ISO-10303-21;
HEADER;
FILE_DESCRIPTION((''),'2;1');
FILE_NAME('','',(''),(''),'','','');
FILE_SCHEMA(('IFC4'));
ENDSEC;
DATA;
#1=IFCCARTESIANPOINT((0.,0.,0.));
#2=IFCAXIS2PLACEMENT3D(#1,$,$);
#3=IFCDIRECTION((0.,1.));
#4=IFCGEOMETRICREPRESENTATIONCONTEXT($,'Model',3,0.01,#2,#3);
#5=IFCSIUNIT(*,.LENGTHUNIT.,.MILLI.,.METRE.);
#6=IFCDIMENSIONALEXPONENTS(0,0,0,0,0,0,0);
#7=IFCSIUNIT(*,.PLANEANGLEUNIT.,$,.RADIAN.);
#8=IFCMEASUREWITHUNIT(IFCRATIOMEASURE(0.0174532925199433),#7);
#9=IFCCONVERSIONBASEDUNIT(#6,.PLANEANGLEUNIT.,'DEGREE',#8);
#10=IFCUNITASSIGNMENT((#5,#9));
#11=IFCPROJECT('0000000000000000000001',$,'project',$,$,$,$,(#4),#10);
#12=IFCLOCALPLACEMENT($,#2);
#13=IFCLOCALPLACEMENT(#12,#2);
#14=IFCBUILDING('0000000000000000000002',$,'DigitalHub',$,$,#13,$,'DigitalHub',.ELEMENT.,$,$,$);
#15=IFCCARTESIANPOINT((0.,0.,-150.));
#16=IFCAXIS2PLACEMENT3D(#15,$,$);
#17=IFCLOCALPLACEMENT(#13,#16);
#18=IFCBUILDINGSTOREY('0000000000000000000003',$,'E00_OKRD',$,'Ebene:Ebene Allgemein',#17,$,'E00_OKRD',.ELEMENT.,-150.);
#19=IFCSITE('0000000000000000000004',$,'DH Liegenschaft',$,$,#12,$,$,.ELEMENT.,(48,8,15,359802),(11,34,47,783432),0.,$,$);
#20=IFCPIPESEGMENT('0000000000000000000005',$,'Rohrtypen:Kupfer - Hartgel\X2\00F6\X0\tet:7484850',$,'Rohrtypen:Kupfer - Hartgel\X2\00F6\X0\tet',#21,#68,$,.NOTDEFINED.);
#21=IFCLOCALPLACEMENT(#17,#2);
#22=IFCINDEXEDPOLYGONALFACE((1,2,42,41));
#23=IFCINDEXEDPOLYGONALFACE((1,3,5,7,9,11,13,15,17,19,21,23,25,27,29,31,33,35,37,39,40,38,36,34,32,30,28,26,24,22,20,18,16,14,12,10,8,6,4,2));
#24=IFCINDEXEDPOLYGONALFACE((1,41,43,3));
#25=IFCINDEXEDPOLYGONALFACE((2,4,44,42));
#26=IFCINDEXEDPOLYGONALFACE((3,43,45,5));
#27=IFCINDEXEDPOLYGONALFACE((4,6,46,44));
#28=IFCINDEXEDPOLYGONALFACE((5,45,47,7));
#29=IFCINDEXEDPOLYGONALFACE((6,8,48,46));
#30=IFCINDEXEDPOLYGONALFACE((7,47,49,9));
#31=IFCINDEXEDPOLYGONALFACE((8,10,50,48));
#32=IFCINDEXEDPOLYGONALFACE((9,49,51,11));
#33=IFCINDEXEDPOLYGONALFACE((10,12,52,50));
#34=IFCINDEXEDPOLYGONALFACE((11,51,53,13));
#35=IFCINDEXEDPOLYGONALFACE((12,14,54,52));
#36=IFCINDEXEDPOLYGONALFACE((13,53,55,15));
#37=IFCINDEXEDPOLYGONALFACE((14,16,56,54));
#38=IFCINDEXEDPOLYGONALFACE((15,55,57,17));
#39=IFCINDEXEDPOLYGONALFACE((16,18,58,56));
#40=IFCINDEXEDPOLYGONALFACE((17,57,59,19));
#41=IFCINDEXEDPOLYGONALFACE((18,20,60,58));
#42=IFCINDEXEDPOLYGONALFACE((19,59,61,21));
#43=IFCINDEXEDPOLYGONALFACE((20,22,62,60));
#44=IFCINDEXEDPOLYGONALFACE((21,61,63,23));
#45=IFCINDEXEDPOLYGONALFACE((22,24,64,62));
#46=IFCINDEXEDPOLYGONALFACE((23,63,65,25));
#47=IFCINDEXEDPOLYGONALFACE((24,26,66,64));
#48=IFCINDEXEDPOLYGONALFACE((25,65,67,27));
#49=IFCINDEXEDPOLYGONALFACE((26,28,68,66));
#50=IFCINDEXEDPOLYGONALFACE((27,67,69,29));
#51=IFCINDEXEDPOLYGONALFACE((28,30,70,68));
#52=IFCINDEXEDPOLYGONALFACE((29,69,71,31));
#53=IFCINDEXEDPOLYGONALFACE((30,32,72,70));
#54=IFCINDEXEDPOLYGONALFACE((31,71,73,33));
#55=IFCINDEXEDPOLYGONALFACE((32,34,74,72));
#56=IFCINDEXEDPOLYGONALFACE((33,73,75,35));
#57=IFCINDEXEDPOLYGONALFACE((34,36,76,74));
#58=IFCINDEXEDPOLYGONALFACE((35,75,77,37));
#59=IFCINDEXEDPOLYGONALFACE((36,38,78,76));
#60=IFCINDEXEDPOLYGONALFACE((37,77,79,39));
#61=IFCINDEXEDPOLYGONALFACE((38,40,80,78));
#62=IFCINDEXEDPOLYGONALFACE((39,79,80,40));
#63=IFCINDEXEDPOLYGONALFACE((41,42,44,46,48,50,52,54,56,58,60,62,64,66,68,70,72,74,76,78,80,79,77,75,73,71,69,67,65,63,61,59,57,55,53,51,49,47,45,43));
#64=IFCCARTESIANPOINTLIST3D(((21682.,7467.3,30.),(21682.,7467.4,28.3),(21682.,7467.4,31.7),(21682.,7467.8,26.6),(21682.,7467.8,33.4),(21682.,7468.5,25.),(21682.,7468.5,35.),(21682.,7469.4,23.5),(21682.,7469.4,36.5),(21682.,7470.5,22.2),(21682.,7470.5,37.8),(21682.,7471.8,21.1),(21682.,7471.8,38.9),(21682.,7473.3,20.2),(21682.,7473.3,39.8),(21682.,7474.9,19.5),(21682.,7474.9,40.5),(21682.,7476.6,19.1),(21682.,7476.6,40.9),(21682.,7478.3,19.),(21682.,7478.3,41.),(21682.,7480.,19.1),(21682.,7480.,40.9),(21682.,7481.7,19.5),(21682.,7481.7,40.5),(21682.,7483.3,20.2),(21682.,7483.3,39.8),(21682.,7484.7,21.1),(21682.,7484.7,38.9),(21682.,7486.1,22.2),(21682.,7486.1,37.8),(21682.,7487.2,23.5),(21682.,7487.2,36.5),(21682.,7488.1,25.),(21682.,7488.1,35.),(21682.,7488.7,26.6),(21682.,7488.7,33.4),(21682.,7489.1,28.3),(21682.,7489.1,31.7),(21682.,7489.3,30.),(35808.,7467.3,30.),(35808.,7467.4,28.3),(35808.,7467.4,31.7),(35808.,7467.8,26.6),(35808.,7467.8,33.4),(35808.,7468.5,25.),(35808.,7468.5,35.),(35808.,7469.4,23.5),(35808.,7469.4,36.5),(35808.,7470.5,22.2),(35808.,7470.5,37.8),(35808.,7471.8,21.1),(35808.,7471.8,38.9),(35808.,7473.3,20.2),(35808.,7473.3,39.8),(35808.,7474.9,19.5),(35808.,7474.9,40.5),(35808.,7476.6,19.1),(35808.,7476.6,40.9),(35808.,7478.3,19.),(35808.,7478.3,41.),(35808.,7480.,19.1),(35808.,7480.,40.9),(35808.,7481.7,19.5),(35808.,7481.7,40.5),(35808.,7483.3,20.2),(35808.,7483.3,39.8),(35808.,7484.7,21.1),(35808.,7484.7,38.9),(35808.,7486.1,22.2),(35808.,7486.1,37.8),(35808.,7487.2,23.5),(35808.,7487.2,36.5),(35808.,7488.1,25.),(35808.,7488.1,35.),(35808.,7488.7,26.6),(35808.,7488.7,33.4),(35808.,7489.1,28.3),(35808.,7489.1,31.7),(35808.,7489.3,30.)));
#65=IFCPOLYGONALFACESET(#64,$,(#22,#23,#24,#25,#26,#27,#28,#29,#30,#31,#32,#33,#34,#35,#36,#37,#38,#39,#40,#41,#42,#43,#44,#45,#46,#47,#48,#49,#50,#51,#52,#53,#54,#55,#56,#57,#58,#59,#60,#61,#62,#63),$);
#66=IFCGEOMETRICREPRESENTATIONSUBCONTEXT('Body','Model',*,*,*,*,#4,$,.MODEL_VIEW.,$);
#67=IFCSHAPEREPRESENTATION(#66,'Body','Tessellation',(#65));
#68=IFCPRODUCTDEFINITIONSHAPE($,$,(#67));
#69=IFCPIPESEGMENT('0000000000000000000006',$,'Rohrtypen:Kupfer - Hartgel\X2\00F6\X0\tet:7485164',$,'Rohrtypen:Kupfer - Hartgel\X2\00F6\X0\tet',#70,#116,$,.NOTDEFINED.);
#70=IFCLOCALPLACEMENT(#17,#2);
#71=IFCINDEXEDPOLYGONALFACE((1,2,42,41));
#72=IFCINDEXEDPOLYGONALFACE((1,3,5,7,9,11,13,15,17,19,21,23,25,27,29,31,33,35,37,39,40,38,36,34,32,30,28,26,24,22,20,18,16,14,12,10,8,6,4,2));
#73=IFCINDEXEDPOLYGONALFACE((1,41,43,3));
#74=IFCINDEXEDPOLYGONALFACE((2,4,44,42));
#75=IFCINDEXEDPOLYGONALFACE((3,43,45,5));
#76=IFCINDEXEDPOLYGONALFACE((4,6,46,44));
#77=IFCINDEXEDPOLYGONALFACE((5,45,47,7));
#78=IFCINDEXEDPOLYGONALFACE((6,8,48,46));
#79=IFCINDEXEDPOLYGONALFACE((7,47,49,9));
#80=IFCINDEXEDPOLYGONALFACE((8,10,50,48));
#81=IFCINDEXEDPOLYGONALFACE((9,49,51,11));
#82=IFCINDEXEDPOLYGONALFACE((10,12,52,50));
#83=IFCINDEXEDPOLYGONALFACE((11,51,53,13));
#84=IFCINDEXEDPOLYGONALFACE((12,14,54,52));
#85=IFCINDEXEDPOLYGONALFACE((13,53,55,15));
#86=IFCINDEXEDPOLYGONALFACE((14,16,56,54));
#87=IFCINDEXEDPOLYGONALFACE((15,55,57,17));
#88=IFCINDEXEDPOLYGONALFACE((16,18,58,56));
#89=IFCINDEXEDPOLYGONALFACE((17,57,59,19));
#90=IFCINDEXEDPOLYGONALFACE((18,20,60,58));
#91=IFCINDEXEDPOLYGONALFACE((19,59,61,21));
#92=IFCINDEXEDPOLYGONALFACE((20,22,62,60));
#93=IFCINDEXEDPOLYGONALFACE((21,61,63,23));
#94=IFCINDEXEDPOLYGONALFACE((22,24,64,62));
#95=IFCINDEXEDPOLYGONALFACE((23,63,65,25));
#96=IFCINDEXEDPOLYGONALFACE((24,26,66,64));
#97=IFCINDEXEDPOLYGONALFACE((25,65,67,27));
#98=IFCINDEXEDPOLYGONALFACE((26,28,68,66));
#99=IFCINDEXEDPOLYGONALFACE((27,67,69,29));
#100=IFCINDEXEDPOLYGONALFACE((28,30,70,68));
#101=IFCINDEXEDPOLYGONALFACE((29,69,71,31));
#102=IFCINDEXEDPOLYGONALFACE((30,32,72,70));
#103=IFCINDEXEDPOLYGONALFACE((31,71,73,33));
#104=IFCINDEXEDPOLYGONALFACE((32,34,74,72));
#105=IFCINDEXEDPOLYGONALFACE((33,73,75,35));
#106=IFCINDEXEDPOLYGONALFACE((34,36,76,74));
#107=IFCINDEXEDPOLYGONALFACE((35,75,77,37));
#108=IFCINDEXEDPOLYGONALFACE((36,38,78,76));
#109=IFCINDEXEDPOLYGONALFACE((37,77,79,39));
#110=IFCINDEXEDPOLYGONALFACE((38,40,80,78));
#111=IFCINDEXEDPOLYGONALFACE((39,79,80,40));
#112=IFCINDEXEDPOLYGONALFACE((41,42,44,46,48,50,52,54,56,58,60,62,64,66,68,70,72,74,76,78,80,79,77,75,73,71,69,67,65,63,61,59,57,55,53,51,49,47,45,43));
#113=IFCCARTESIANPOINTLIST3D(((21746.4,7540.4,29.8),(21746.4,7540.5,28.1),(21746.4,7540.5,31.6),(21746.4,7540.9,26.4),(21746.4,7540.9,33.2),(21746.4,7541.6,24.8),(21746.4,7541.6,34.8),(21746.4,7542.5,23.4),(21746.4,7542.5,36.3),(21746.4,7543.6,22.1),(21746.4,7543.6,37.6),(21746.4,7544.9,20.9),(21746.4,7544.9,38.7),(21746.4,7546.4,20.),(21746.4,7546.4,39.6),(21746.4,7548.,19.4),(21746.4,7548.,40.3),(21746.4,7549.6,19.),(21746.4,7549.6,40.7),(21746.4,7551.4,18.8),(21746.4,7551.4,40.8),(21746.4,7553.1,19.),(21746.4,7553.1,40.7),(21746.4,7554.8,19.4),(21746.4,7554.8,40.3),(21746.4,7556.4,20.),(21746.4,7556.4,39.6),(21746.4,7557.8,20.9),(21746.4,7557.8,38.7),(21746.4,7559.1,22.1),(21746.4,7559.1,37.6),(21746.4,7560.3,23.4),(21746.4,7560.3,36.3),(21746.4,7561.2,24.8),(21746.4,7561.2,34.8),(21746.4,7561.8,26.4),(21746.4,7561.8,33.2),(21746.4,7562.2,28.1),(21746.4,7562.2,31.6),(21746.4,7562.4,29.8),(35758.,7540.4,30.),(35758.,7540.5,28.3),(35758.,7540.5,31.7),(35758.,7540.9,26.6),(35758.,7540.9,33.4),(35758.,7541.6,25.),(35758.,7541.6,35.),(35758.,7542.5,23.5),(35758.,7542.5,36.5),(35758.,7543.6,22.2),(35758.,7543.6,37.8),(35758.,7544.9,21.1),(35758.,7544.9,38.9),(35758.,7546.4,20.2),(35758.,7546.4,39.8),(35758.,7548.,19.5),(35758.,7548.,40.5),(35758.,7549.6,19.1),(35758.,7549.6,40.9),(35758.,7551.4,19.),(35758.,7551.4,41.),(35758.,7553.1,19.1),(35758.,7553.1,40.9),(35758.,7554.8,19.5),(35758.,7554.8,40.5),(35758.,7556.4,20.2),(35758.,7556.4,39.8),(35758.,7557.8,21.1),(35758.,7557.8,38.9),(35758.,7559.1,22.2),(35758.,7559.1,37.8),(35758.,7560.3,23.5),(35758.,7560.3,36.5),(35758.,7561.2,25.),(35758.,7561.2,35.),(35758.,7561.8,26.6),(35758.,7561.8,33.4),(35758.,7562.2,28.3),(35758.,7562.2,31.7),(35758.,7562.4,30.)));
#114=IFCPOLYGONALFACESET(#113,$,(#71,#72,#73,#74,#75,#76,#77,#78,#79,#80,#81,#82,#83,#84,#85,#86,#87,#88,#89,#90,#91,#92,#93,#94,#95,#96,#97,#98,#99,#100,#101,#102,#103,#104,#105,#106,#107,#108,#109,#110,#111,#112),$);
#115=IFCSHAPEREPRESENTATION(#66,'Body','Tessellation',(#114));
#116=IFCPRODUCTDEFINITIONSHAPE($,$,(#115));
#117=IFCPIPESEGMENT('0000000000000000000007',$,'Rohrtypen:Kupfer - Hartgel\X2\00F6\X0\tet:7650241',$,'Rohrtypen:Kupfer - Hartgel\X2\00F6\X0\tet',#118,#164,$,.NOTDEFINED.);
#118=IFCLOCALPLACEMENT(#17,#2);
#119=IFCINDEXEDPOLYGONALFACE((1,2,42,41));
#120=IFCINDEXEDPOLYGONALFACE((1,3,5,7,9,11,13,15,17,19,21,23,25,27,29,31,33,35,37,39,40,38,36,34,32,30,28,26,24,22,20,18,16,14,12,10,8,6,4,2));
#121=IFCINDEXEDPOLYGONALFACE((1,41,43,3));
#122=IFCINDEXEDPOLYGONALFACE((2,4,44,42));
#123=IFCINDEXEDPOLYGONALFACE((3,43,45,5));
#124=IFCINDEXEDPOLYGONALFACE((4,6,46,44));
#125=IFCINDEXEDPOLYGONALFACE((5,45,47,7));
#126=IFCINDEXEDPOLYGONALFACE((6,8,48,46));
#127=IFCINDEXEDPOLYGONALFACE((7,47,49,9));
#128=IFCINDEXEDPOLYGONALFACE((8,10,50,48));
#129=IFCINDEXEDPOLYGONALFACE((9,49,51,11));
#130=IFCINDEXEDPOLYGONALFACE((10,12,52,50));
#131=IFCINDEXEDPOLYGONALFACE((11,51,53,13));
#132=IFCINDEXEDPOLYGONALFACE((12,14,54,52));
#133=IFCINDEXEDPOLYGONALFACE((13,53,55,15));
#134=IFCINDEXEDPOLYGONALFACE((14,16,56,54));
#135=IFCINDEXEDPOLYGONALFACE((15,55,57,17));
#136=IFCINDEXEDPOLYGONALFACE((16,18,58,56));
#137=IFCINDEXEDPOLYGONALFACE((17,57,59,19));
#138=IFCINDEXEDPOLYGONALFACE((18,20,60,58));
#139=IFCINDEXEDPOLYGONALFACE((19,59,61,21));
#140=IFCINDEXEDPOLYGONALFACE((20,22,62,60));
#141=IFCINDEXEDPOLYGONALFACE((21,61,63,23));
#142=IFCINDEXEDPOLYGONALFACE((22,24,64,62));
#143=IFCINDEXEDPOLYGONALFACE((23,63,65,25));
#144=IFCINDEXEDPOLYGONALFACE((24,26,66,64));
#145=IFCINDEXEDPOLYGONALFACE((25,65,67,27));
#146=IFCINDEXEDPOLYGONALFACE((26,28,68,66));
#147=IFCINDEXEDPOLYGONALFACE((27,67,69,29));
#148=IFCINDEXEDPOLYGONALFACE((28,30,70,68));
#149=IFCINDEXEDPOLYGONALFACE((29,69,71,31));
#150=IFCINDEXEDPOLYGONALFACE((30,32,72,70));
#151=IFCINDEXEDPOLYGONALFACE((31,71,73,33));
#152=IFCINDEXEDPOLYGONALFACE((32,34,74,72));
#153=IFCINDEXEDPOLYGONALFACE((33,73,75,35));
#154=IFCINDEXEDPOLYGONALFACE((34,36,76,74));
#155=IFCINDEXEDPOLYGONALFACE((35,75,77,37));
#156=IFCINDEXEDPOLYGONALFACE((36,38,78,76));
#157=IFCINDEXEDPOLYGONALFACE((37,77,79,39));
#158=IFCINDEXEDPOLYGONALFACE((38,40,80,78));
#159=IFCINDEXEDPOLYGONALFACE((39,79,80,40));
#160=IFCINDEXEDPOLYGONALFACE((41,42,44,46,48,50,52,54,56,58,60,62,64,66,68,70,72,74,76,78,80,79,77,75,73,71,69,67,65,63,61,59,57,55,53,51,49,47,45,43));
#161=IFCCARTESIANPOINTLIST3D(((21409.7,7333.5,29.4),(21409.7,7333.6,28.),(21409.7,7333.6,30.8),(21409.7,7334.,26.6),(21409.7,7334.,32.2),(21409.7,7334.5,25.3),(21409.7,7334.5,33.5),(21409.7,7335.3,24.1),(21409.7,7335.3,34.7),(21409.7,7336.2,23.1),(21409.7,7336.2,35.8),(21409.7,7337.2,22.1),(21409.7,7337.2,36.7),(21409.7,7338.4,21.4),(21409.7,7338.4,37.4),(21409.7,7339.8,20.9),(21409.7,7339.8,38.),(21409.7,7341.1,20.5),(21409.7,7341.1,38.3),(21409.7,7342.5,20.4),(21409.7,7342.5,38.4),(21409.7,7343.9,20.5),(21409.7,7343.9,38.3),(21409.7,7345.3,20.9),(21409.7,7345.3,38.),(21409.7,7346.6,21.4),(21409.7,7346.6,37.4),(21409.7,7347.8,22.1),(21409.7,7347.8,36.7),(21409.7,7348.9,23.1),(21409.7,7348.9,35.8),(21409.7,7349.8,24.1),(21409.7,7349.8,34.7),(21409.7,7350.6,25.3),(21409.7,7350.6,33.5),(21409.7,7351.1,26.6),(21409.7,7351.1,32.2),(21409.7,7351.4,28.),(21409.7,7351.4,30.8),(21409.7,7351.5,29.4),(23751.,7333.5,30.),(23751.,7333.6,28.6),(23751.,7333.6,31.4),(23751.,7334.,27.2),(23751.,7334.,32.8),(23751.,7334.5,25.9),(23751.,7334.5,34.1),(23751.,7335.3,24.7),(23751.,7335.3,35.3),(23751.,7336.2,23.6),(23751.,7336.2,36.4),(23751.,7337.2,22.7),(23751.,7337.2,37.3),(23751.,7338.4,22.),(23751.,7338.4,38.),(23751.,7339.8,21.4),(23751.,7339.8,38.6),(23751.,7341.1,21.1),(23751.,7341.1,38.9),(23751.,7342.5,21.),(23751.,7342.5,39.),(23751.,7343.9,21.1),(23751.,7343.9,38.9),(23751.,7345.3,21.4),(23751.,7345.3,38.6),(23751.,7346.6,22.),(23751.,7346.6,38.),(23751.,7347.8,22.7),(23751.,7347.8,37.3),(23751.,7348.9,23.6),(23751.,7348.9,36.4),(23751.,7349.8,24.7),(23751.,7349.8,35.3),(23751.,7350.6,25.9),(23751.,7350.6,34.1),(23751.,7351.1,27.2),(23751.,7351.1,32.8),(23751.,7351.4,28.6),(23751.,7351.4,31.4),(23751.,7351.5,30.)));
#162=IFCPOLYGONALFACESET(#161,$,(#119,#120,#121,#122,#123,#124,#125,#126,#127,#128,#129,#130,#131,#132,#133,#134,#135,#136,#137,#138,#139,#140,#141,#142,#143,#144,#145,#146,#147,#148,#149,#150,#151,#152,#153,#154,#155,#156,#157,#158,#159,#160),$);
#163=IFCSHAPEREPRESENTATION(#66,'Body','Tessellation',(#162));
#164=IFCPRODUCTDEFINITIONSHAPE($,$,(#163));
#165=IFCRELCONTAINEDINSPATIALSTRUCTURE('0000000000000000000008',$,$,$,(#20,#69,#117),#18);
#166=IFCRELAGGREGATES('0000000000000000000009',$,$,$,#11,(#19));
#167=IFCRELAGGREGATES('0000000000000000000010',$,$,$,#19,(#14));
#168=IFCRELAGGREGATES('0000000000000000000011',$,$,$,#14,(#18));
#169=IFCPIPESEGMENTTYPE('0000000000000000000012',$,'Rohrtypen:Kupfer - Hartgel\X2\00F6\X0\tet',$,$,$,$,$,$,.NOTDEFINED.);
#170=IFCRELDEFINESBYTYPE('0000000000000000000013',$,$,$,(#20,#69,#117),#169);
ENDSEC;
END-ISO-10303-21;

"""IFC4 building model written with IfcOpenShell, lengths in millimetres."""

from ifc_helpers import new_model, entity, si_unit, converted_unit, direction, frame, origin, place, context, subcontext, project, spatial, indexed_curve, outline, extrude, type_object, element, save


model = new_model("IFC4")

# Units and contexts
model_context = context("Model", 3, precision=0.01, world=origin(), true_north=direction((0.0, 1.0)))
body_context = subcontext(model_context, "Body", "Model", "MODEL_VIEW")
ifc_project = project(units=[si_unit("LENGTHUNIT", "METRE", prefix="MILLI"), converted_unit("PLANEANGLEUNIT", "DEGREE", entity("IfcRatioMeasure", 0.0174532925199433), si_unit("PLANEANGLEUNIT", "RADIAN"), dimensions=[0, 0, 0, 0, 0, 0, 0])], contexts=[model_context])

# Site, building, storey
site_placement = place(None, origin())
site = spatial("IfcSite", under=ifc_project, at=site_placement, Name="DH Liegenschaft", CompositionType="ELEMENT", RefLatitude=(48, 8, 15, 359802), RefLongitude=(11, 34, 47, 783432), RefElevation=0.0)
building_placement = place(site_placement, origin())
building = spatial("IfcBuilding", under=site, at=building_placement, Name="DigitalHub", LongName="DigitalHub", CompositionType="ELEMENT")
storey_placement = place(building_placement, frame((0.0, 0.0, -150.0)))
storey = spatial("IfcBuildingStorey", under=building, at=storey_placement, Name="E00_OKRD", ObjectType="Ebene:Ebene Allgemein", LongName="E00_OKRD", CompositionType="ELEMENT", Elevation=-150.0)

# Pipe segments
pipe_segment_type = type_object("IfcPipeSegmentType", Name="Rohrtypen:Kupfer - Hartgelötet", PredefinedType="NOTDEFINED")
pipe_segment_1_placement = place(storey_placement, frame((21682.0, 7465.7, 17.4)))
element("IfcPipeSegment", 1, at=pipe_segment_1_placement, inside=storey, type_object=pipe_segment_type, Name="Rohrtypen:Kupfer - Hartgelötet:7484850", ObjectType="Rohrtypen:Kupfer - Hartgelötet", PredefinedType="NOTDEFINED", context=body_context, shape_type="SweptSolid", body=[
    extrude(outline(indexed_curve([(11.0, 0.0), (10.9, 1.7), (10.5, 3.4), (9.8, 5.0), (8.9, 6.5), (7.8, 7.8), (6.5, 8.9), (5.0, 9.8), (3.4, 10.5), (1.7, 10.9), (0.0, 11.0), (-1.7, 10.9), (-3.4, 10.5), (-5.0, 9.8), (-6.5, 8.9), (-7.8, 7.8), (-8.9, 6.5), (-9.8, 5.0), (-10.5, 3.4), (-10.9, 1.7), (-11.0, 0.0), (-10.9, -1.7), (-10.5, -3.4), (-9.8, -5.0), (-8.9, -6.5), (-7.8, -7.8), (-6.5, -8.9), (-5.0, -9.8), (-3.4, -10.5), (-1.7, -10.9), (0.0, -11.0), (1.7, -10.9), (3.4, -10.5), (5.0, -9.8), (6.5, -8.9), (7.8, -7.8), (8.9, -6.5), (9.8, -5.0), (10.5, -3.4), (10.9, -1.7), (11.0, 0.0)], self_intersect=False)), frame((0.0, 12.6, 12.6), z_axis=(1.0, 0.0, 0.0), x_axis=(0.0, 1.0, 0.0)), (0.0, 0.0, 1.0), 14126.0),
])
pipe_segment_2_placement = place(storey_placement, frame((21746.4, 7538.8, 17.2)))
element("IfcPipeSegment", 2, at=pipe_segment_2_placement, inside=storey, type_object=pipe_segment_type, Name="Rohrtypen:Kupfer - Hartgelötet:7485164", ObjectType="Rohrtypen:Kupfer - Hartgelötet", PredefinedType="NOTDEFINED", context=body_context, shape_type="SweptSolid", body=[
    extrude(outline(indexed_curve([(11.0, 0.0), (10.9, 1.7), (10.5, 3.4), (9.8, 5.0), (8.9, 6.5), (7.8, 7.8), (6.5, 8.9), (5.0, 9.8), (3.4, 10.5), (1.7, 10.9), (0.0, 11.0), (-1.7, 10.9), (-3.4, 10.5), (-5.0, 9.8), (-6.5, 8.9), (-7.8, 7.8), (-8.9, 6.5), (-9.8, 5.0), (-10.5, 3.4), (-10.9, 1.7), (-11.0, 0.0), (-10.9, -1.7), (-10.5, -3.4), (-9.8, -5.0), (-8.9, -6.5), (-7.8, -7.8), (-6.5, -8.9), (-5.0, -9.8), (-3.4, -10.5), (-1.7, -10.9), (0.0, -11.0), (1.7, -10.9), (3.4, -10.5), (5.0, -9.8), (6.5, -8.9), (7.8, -7.8), (8.9, -6.5), (9.8, -5.0), (10.5, -3.4), (10.9, -1.7), (11.0, 0.0)], self_intersect=False)), frame((0.0, 12.6, 12.6), z_axis=(1.0, 0.0, 0.000012), x_axis=(0.0, -1.0, 0.0)), (0.0, 0.0, 1.0), 14011.5),
])
pipe_segment_3_placement = place(storey_placement, frame((21409.7, 7331.9, 18.8)))
element("IfcPipeSegment", 3, at=pipe_segment_3_placement, inside=storey, type_object=pipe_segment_type, Name="Rohrtypen:Kupfer - Hartgelötet:7650241", ObjectType="Rohrtypen:Kupfer - Hartgelötet", PredefinedType="NOTDEFINED", context=body_context, shape_type="SweptSolid", body=[
    extrude(outline(indexed_curve([(9.0, 0.0), (8.9, 1.4), (8.6, 2.8), (8.0, 4.1), (7.3, 5.3), (6.4, 6.4), (5.3, 7.3), (4.1, 8.0), (2.8, 8.6), (1.4, 8.9), (0.0, 9.0), (-1.4, 8.9), (-2.8, 8.6), (-4.1, 8.0), (-5.3, 7.3), (-6.4, 6.4), (-7.3, 5.3), (-8.0, 4.1), (-8.6, 2.8), (-8.9, 1.4), (-9.0, 0.0), (-8.9, -1.4), (-8.6, -2.8), (-8.0, -4.1), (-7.3, -5.3), (-6.4, -6.4), (-5.3, -7.3), (-4.1, -8.0), (-2.8, -8.6), (-1.4, -8.9), (0.0, -9.0), (1.4, -8.9), (2.8, -8.6), (4.1, -8.0), (5.3, -7.3), (6.4, -6.4), (7.3, -5.3), (8.0, -4.1), (8.6, -2.8), (8.9, -1.4), (9.0, 0.0)], self_intersect=False)), frame((0.0, 10.6, 10.6), z_axis=(1.0, 0.0, 0.000244), x_axis=(0.0, -1.0, 0.0)), (0.0, 0.0, 1.0), 2341.3),
])

save(model, "model.ifc")
